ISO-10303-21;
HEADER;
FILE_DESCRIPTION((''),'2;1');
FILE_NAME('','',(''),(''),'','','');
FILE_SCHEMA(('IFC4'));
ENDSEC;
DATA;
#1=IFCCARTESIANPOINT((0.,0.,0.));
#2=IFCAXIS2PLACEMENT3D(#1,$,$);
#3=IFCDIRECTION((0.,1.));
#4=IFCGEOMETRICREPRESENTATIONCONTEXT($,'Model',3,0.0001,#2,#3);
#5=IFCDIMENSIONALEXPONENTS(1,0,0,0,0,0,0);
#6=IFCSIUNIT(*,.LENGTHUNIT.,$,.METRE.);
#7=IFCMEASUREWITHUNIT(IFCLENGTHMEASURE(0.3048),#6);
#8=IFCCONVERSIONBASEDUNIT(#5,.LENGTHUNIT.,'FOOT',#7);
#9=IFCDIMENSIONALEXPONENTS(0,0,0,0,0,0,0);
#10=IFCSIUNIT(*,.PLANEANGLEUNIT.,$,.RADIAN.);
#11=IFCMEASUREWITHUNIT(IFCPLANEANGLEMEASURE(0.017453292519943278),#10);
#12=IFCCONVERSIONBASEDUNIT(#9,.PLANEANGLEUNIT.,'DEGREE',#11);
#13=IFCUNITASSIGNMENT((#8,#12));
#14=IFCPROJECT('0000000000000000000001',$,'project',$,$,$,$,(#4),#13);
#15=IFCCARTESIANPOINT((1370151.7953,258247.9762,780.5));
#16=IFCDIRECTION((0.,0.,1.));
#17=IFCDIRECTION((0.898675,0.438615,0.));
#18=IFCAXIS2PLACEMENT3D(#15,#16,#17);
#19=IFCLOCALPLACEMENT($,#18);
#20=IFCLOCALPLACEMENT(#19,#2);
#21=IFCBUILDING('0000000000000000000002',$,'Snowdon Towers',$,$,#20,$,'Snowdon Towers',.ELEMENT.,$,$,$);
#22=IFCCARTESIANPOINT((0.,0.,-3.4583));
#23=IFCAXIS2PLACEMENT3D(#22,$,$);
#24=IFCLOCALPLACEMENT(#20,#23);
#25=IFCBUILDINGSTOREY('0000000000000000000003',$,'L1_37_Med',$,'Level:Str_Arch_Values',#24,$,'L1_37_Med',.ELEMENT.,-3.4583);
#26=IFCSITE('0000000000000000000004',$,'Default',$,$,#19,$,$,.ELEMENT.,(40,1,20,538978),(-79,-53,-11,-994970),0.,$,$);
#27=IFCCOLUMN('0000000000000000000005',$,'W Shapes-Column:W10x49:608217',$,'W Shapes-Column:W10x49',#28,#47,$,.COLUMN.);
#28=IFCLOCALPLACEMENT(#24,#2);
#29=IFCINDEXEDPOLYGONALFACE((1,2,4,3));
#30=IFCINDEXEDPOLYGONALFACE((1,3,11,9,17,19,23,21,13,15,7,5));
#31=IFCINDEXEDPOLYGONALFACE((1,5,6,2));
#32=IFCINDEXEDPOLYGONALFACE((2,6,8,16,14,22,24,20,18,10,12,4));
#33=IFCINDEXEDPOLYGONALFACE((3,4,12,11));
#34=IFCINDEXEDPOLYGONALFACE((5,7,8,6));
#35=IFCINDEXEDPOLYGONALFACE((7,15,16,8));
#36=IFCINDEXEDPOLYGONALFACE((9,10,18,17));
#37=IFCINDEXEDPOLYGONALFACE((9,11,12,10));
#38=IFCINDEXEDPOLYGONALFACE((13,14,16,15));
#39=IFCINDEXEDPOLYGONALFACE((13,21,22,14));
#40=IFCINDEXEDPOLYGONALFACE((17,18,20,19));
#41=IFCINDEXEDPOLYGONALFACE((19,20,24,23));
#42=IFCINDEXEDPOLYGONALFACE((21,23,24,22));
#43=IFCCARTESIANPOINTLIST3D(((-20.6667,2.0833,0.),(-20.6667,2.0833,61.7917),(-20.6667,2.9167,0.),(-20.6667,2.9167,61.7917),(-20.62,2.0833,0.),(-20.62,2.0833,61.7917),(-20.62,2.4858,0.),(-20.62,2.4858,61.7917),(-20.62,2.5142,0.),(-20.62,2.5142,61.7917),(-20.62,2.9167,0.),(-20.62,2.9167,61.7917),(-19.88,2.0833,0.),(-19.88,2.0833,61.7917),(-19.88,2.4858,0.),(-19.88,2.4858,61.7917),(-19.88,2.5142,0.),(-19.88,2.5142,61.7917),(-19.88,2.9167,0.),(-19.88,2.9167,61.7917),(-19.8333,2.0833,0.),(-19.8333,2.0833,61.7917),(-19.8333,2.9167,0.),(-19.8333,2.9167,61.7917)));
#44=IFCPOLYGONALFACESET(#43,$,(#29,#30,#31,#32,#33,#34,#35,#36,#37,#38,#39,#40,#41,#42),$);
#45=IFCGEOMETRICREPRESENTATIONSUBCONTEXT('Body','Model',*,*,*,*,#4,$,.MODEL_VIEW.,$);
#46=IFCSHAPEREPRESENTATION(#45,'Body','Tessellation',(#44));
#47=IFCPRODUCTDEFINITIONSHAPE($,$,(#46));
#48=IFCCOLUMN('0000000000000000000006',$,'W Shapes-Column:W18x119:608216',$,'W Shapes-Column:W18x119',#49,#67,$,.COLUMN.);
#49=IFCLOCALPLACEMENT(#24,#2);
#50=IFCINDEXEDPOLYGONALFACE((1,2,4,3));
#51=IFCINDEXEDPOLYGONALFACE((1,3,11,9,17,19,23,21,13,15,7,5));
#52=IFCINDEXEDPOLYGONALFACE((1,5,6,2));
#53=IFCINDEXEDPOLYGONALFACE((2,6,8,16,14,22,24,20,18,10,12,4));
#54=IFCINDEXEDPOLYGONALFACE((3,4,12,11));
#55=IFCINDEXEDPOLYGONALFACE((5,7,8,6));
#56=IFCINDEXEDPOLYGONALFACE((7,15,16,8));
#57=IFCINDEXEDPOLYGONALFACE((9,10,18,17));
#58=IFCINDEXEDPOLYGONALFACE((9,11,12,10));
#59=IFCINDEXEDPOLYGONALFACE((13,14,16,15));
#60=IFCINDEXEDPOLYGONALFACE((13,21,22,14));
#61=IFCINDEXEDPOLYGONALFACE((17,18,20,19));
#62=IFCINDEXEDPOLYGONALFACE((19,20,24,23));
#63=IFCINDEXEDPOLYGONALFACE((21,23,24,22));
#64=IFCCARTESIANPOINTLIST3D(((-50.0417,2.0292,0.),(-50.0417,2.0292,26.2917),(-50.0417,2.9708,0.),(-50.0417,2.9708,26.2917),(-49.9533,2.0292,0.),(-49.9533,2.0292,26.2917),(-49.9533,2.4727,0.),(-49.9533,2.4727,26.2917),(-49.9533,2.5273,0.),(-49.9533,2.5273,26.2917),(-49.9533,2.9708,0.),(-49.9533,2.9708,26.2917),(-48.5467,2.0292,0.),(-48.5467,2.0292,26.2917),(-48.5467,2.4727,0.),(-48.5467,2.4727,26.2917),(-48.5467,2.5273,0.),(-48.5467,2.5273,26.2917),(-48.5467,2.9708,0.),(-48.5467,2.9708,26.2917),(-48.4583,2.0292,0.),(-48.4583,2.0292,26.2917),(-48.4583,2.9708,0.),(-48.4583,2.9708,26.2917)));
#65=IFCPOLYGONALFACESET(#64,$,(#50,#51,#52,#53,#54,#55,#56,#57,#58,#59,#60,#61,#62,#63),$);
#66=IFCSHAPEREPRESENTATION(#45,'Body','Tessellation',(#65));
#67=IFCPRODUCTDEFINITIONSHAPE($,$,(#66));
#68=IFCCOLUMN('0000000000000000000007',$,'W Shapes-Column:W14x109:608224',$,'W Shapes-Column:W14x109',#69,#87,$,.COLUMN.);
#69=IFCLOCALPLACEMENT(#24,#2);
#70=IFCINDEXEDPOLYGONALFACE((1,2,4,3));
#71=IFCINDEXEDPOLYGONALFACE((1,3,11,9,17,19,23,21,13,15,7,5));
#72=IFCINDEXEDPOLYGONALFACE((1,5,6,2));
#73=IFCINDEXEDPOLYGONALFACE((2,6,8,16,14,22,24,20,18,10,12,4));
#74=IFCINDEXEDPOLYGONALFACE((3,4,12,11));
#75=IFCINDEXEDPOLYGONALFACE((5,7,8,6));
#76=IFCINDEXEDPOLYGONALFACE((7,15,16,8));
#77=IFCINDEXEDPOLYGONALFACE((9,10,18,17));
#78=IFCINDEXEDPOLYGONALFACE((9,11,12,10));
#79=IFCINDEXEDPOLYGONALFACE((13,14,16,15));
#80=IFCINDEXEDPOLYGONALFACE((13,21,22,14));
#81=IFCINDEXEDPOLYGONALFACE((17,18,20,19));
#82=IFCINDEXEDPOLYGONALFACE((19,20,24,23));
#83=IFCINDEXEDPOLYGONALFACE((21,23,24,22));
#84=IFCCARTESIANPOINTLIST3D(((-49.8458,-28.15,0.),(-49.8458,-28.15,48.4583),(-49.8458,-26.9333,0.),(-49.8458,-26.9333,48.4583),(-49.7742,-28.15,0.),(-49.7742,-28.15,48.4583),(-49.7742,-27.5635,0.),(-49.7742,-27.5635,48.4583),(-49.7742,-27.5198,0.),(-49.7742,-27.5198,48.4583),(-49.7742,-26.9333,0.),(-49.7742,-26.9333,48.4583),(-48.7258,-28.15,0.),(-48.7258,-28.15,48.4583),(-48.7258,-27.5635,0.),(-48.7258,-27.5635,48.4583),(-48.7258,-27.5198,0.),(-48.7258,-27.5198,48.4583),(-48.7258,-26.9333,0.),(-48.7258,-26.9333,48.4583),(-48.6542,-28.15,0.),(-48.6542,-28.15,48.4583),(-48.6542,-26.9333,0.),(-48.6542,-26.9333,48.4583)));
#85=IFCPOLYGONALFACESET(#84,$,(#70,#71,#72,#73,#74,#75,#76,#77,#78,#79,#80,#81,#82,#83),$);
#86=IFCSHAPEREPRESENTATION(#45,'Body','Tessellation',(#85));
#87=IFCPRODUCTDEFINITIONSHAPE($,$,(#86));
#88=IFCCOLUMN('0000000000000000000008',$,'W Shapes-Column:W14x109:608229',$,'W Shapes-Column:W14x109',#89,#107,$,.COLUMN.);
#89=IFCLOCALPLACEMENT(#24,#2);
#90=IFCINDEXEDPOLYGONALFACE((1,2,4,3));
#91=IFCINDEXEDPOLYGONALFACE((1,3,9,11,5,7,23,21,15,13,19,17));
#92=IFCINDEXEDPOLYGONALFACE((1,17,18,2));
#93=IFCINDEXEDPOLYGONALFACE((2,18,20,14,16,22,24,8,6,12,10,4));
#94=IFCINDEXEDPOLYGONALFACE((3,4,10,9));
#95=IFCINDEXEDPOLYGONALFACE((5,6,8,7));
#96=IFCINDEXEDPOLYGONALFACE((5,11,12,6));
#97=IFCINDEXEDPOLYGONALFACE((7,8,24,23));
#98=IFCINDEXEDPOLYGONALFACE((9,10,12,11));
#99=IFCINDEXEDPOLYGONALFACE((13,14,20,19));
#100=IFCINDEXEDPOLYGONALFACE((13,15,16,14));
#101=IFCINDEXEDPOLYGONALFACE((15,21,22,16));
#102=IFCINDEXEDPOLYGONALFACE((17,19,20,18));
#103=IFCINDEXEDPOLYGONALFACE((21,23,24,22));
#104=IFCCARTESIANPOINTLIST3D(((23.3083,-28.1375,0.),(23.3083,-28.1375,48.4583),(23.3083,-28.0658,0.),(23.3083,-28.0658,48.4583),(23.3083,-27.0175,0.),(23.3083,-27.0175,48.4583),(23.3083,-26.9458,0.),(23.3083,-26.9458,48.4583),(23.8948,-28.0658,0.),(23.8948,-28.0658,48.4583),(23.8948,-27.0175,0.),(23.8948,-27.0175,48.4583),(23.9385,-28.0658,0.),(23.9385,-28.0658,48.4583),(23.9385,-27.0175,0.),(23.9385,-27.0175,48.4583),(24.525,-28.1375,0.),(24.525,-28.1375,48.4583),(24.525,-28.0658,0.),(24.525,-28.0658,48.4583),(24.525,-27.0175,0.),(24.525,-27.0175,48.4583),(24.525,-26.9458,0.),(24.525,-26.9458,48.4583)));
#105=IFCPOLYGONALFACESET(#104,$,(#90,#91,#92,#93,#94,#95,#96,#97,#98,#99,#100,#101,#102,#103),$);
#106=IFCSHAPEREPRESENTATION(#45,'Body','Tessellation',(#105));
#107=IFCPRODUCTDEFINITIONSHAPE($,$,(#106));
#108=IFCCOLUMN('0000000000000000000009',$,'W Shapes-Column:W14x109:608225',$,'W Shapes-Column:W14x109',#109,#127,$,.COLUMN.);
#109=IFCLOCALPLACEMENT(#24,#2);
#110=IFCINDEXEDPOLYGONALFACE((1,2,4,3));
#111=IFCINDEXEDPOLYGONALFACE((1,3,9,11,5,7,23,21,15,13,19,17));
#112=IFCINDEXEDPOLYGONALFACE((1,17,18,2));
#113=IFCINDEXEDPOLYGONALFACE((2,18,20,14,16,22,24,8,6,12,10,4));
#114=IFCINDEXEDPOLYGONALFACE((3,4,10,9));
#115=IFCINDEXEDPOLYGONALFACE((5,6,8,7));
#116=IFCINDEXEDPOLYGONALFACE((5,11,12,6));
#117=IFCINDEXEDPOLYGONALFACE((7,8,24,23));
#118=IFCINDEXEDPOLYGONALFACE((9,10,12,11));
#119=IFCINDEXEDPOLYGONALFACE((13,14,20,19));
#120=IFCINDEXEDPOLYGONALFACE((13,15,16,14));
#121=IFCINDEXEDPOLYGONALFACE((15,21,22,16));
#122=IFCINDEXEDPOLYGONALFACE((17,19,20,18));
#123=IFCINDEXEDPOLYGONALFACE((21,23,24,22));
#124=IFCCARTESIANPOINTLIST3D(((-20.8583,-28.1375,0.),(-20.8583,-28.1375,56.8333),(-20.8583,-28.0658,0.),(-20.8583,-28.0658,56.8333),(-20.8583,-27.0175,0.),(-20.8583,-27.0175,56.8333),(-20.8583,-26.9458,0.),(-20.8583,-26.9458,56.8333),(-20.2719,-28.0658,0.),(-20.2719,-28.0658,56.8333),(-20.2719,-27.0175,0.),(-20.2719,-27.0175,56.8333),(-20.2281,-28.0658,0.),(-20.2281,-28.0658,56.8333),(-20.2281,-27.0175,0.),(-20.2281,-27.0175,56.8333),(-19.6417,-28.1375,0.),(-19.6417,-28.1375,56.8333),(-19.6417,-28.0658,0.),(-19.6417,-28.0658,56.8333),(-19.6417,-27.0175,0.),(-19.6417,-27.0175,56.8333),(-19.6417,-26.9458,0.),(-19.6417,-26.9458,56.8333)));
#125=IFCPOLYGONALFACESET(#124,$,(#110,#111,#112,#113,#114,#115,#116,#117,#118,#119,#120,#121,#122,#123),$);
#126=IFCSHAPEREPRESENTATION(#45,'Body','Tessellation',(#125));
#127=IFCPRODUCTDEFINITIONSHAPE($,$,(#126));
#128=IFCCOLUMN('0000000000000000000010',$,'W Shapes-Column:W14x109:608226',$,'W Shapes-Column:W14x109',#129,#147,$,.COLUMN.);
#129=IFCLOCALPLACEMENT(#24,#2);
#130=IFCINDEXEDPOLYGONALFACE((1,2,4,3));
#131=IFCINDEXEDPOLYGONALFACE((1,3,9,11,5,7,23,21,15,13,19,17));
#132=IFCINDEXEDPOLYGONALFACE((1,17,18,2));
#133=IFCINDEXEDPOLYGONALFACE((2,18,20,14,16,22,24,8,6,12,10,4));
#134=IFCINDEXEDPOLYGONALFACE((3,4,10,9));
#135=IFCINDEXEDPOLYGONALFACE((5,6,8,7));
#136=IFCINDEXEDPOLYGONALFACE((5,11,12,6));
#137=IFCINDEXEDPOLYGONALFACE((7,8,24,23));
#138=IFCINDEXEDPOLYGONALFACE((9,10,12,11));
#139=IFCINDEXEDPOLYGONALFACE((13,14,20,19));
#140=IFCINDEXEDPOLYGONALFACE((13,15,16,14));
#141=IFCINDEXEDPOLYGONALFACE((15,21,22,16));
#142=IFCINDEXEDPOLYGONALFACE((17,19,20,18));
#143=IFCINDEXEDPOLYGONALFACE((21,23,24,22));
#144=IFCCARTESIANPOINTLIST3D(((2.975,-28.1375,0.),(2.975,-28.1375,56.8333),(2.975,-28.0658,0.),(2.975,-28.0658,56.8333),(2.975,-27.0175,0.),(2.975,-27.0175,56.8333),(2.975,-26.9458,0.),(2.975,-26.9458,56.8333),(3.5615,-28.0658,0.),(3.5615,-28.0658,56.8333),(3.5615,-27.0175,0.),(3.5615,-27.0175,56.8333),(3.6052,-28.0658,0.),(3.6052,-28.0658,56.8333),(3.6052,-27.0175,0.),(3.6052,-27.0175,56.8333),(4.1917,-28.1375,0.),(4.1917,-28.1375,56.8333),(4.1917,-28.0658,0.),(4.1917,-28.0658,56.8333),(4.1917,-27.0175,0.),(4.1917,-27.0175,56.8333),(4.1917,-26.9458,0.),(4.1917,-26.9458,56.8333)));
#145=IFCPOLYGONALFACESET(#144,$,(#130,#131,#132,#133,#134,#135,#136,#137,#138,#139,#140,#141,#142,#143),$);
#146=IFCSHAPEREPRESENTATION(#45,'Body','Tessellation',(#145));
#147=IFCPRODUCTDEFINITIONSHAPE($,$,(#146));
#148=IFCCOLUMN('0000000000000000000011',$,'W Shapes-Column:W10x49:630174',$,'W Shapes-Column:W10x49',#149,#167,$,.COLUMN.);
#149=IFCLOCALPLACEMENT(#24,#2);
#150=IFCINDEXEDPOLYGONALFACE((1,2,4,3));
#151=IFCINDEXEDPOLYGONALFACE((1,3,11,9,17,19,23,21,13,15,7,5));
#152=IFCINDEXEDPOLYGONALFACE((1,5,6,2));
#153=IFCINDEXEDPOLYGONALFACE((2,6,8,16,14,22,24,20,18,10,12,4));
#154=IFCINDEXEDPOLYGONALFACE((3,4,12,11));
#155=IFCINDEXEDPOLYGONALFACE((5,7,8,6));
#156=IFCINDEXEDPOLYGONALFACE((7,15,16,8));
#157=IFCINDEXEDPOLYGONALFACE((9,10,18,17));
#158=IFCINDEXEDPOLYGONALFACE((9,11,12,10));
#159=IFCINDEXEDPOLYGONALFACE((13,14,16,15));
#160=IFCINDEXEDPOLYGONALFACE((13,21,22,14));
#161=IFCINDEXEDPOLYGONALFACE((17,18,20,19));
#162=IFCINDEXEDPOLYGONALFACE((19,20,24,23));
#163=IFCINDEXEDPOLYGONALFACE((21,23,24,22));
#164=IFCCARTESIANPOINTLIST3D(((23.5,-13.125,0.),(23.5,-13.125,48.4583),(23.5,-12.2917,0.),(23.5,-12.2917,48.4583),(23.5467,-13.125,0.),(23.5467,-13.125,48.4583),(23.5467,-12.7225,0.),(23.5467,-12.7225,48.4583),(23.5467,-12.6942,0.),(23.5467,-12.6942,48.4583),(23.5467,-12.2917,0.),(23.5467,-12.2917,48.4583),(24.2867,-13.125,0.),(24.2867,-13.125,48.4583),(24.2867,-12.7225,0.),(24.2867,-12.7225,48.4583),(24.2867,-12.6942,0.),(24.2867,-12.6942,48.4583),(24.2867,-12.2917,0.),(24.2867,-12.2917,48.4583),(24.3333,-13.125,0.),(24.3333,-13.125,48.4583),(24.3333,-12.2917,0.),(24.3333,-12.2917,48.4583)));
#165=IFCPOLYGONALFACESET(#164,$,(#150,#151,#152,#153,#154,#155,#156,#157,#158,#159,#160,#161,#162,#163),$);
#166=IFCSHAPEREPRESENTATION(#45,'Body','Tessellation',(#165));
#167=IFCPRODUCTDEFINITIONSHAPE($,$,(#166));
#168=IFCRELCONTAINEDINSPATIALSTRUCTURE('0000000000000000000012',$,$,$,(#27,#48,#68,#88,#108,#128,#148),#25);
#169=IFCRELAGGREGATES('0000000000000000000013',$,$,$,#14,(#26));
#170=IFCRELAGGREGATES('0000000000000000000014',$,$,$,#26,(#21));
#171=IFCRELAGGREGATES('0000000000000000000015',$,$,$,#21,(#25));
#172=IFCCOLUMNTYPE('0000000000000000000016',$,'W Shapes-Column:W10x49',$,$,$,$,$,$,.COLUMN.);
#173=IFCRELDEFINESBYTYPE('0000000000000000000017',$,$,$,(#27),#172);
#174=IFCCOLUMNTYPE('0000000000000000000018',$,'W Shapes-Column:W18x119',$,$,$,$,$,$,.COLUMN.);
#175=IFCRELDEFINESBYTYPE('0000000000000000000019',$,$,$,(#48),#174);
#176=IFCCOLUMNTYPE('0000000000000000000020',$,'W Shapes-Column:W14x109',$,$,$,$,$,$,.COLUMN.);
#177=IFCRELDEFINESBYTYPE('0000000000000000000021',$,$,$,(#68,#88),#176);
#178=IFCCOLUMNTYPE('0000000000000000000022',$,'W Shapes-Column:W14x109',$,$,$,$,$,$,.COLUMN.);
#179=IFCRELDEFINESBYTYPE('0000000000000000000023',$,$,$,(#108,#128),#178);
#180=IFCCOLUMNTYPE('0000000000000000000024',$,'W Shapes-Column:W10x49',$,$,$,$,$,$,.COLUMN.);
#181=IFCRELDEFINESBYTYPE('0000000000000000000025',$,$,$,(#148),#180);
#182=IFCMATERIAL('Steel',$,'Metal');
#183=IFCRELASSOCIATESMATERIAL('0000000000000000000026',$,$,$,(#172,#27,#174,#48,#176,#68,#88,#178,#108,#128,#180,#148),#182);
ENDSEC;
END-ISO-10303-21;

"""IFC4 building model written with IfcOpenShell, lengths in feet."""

from ifc_helpers import new_model, entity, si_unit, converted_unit, direction, frame, origin, place, context, subcontext, project, spatial, indexed_curve, outline, extrude, source, transform, mapped, material, type_object, type_shapes, element, save


model = new_model("IFC4")

# Units and contexts
model_context = context("Model", 3, precision=0.0001, world=origin(), true_north=direction((0.0, 1.0)))
body_context = subcontext(model_context, "Body", "Model", "MODEL_VIEW")
ifc_project = project(units=[converted_unit("LENGTHUNIT", "FOOT", entity("IfcLengthMeasure", 0.3048), si_unit("LENGTHUNIT", "METRE"), dimensions=[1, 0, 0, 0, 0, 0, 0]), converted_unit("PLANEANGLEUNIT", "DEGREE", entity("IfcPlaneAngleMeasure", 0.017453292519943278), si_unit("PLANEANGLEUNIT", "RADIAN"), dimensions=[0, 0, 0, 0, 0, 0, 0])], contexts=[model_context])

# Site, building, storey
site_placement = place(None, frame((1370151.7953, 258247.9762, 780.5), z_axis=(0.0, 0.0, 1.0), x_axis=(0.898675, 0.438615, 0.0)))
site = spatial("IfcSite", under=ifc_project, at=site_placement, Name="Default", CompositionType="ELEMENT", RefLatitude=(40, 1, 20, 538978), RefLongitude=(-79, -53, -11, -994970), RefElevation=0.0)
building_placement = place(site_placement, origin())
building = spatial("IfcBuilding", under=site, at=building_placement, Name="Snowdon Towers", LongName="Snowdon Towers", CompositionType="ELEMENT")
storey_placement = place(building_placement, frame((0.0, 0.0, -3.4583)))
storey = spatial("IfcBuildingStorey", under=building, at=storey_placement, Name="L1_37_Med", ObjectType="Level:Str_Arch_Values", LongName="L1_37_Med", CompositionType="ELEMENT", Elevation=-3.4583)

# Columns
ifc_material_1 = material(Name="Steel", Category="Metal")
column_type_1 = type_object("IfcColumnType", Name="W Shapes-Column:W10x49", PredefinedType="COLUMN", material=ifc_material_1)
shared_shape_1 = source(origin(), body_context, "Body", "SweptSolid", [
    extrude(outline(indexed_curve([(-0.4167, -0.4167), (0.4167, -0.4167), (0.4167, -0.37), (0.0142, -0.37), (0.0142, 0.37), (0.4167, 0.37), (0.4167, 0.4167), (-0.4167, 0.4167), (-0.4167, 0.37), (-0.0142, 0.37), (-0.0142, -0.37), (-0.4167, -0.37), (-0.4167, -0.4167)], self_intersect=False)), frame((0.0, 0.0, -3.4583), z_axis=(0.0, 0.0, 1.0), x_axis=(-1.0, 0.0, 0.0)), (0.0, 0.0, 1.0), 61.7917),
])
type_shapes(column_type_1, [shared_shape_1])
column_1_placement = place(storey_placement, frame((-20.25, 2.5, 3.4583), z_axis=(0.0, 0.0, 1.0), x_axis=(0.0, 1.0, 0.0)))
element("IfcColumn", 1, at=column_1_placement, inside=storey, type_object=column_type_1, material=ifc_material_1, Name="W Shapes-Column:W10x49:608217", ObjectType="W Shapes-Column:W10x49", PredefinedType="COLUMN", context=body_context, shape_type="MappedRepresentation", body=[
    mapped(shared_shape_1, transform((0.0, 0.0, 0.0), scale=1.0)),
])
column_type_2 = type_object("IfcColumnType", Name="W Shapes-Column:W18x119", PredefinedType="COLUMN", material=ifc_material_1)
shared_shape_2 = source(origin(), body_context, "Body", "SweptSolid", [
    extrude(outline(indexed_curve([(-0.4708, -0.7917), (0.4708, -0.7917), (0.4708, -0.7033), (0.0273, -0.7033), (0.0273, 0.7033), (0.4708, 0.7033), (0.4708, 0.7917), (-0.4708, 0.7917), (-0.4708, 0.7033), (-0.0273, 0.7033), (-0.0273, -0.7033), (-0.4708, -0.7033), (-0.4708, -0.7917)], self_intersect=False)), frame((0.0, 0.0, -3.4583), z_axis=(0.0, 0.0, 1.0), x_axis=(-1.0, 0.0, 0.0)), (0.0, 0.0, 1.0), 26.2917),
])
type_shapes(column_type_2, [shared_shape_2])
column_2_placement = place(storey_placement, frame((-49.25, 2.5, 3.4583), z_axis=(0.0, 0.0, 1.0), x_axis=(0.0, -1.0, 0.0)))
element("IfcColumn", 2, at=column_2_placement, inside=storey, type_object=column_type_2, material=ifc_material_1, Name="W Shapes-Column:W18x119:608216", ObjectType="W Shapes-Column:W18x119", PredefinedType="COLUMN", context=body_context, shape_type="MappedRepresentation", body=[
    mapped(shared_shape_2, transform((0.0, 0.0, 0.0), scale=1.0)),
])
column_type_3 = type_object("IfcColumnType", Name="W Shapes-Column:W14x109", PredefinedType="COLUMN", material=ifc_material_1)
shared_shape_3 = source(origin(), body_context, "Body", "SweptSolid", [
    extrude(outline(indexed_curve([(-0.6083, -0.5958), (0.6083, -0.5958), (0.6083, -0.5242), (0.0219, -0.5242), (0.0219, 0.5242), (0.6083, 0.5242), (0.6083, 0.5958), (-0.6083, 0.5958), (-0.6083, 0.5242), (-0.0219, 0.5242), (-0.0219, -0.5242), (-0.6083, -0.5242), (-0.6083, -0.5958)], self_intersect=False)), frame((0.0, 0.0, -3.4583), z_axis=(0.0, 0.0, 1.0), x_axis=(-1.0, 0.0, 0.0)), (0.0, 0.0, 1.0), 48.4583),
])
type_shapes(column_type_3, [shared_shape_3])
for number, where, z_axis, x_axis, name in (
    (3, (-49.25, -27.5417, 3.4583), (0.0, 0.0, 1.0), (0.0, 1.0, 0.0), "W Shapes-Column:W14x109:608224"),
    (4, (23.9167, -27.5417, 3.4583), (0.0, 0.0, 1.0), (-1.0, 0.0, 0.0), "W Shapes-Column:W14x109:608229"),
):
    element("IfcColumn", number, at=place(storey_placement, frame(where, z_axis=z_axis, x_axis=x_axis)), inside=storey, type_object=column_type_3, material=ifc_material_1, Name=name, ObjectType="W Shapes-Column:W14x109", PredefinedType="COLUMN", context=body_context, shape_type="MappedRepresentation", body=[
        mapped(shared_shape_3, transform((0.0, 0.0, 0.0), scale=1.0)),
    ])
column_type_4 = type_object("IfcColumnType", Name="W Shapes-Column:W14x109", PredefinedType="COLUMN", material=ifc_material_1)
shared_shape_4 = source(origin(), body_context, "Body", "SweptSolid", [
    extrude(outline(indexed_curve([(-0.6083, -0.5958), (0.6083, -0.5958), (0.6083, -0.5242), (0.0219, -0.5242), (0.0219, 0.5242), (0.6083, 0.5242), (0.6083, 0.5958), (-0.6083, 0.5958), (-0.6083, 0.5242), (-0.0219, 0.5242), (-0.0219, -0.5242), (-0.6083, -0.5242), (-0.6083, -0.5958)], self_intersect=False)), frame((0.0, 0.0, -3.4583), z_axis=(0.0, 0.0, 1.0), x_axis=(-1.0, 0.0, 0.0)), (0.0, 0.0, 1.0), 56.8333),
])
type_shapes(column_type_4, [shared_shape_4])
for number, where, z_axis, x_axis, name in (
    (5, (-20.25, -27.5417, 3.4583), (0.0, 0.0, 1.0), (-1.0, 0.0, 0.0), "W Shapes-Column:W14x109:608225"),
    (6, (3.5833, -27.5417, 3.4583), (0.0, 0.0, 1.0), (-1.0, 0.0, 0.0), "W Shapes-Column:W14x109:608226"),
):
    element("IfcColumn", number, at=place(storey_placement, frame(where, z_axis=z_axis, x_axis=x_axis)), inside=storey, type_object=column_type_4, material=ifc_material_1, Name=name, ObjectType="W Shapes-Column:W14x109", PredefinedType="COLUMN", context=body_context, shape_type="MappedRepresentation", body=[
        mapped(shared_shape_4, transform((0.0, 0.0, 0.0), scale=1.0)),
    ])
column_type_5 = type_object("IfcColumnType", Name="W Shapes-Column:W10x49", PredefinedType="COLUMN", material=ifc_material_1)
shared_shape_5 = source(origin(), body_context, "Body", "SweptSolid", [
    extrude(outline(indexed_curve([(-0.4167, -0.4167), (0.4167, -0.4167), (0.4167, -0.37), (0.0142, -0.37), (0.0142, 0.37), (0.4167, 0.37), (0.4167, 0.4167), (-0.4167, 0.4167), (-0.4167, 0.37), (-0.0142, 0.37), (-0.0142, -0.37), (-0.4167, -0.37), (-0.4167, -0.4167)], self_intersect=False)), frame((0.0, 0.0, -3.4583), z_axis=(0.0, 0.0, 1.0), x_axis=(-1.0, 0.0, 0.0)), (0.0, 0.0, 1.0), 48.4583),
])
type_shapes(column_type_5, [shared_shape_5])
column_3_placement = place(storey_placement, frame((23.9167, -12.7083, 3.4583), z_axis=(0.0, 0.0, 1.0), x_axis=(0.0, 1.0, 0.0)))
element("IfcColumn", 7, at=column_3_placement, inside=storey, type_object=column_type_5, material=ifc_material_1, Name="W Shapes-Column:W10x49:630174", ObjectType="W Shapes-Column:W10x49", PredefinedType="COLUMN", context=body_context, shape_type="MappedRepresentation", body=[
    mapped(shared_shape_5, transform((0.0, 0.0, 0.0), scale=1.0)),
])

save(model, "model.ifc")
